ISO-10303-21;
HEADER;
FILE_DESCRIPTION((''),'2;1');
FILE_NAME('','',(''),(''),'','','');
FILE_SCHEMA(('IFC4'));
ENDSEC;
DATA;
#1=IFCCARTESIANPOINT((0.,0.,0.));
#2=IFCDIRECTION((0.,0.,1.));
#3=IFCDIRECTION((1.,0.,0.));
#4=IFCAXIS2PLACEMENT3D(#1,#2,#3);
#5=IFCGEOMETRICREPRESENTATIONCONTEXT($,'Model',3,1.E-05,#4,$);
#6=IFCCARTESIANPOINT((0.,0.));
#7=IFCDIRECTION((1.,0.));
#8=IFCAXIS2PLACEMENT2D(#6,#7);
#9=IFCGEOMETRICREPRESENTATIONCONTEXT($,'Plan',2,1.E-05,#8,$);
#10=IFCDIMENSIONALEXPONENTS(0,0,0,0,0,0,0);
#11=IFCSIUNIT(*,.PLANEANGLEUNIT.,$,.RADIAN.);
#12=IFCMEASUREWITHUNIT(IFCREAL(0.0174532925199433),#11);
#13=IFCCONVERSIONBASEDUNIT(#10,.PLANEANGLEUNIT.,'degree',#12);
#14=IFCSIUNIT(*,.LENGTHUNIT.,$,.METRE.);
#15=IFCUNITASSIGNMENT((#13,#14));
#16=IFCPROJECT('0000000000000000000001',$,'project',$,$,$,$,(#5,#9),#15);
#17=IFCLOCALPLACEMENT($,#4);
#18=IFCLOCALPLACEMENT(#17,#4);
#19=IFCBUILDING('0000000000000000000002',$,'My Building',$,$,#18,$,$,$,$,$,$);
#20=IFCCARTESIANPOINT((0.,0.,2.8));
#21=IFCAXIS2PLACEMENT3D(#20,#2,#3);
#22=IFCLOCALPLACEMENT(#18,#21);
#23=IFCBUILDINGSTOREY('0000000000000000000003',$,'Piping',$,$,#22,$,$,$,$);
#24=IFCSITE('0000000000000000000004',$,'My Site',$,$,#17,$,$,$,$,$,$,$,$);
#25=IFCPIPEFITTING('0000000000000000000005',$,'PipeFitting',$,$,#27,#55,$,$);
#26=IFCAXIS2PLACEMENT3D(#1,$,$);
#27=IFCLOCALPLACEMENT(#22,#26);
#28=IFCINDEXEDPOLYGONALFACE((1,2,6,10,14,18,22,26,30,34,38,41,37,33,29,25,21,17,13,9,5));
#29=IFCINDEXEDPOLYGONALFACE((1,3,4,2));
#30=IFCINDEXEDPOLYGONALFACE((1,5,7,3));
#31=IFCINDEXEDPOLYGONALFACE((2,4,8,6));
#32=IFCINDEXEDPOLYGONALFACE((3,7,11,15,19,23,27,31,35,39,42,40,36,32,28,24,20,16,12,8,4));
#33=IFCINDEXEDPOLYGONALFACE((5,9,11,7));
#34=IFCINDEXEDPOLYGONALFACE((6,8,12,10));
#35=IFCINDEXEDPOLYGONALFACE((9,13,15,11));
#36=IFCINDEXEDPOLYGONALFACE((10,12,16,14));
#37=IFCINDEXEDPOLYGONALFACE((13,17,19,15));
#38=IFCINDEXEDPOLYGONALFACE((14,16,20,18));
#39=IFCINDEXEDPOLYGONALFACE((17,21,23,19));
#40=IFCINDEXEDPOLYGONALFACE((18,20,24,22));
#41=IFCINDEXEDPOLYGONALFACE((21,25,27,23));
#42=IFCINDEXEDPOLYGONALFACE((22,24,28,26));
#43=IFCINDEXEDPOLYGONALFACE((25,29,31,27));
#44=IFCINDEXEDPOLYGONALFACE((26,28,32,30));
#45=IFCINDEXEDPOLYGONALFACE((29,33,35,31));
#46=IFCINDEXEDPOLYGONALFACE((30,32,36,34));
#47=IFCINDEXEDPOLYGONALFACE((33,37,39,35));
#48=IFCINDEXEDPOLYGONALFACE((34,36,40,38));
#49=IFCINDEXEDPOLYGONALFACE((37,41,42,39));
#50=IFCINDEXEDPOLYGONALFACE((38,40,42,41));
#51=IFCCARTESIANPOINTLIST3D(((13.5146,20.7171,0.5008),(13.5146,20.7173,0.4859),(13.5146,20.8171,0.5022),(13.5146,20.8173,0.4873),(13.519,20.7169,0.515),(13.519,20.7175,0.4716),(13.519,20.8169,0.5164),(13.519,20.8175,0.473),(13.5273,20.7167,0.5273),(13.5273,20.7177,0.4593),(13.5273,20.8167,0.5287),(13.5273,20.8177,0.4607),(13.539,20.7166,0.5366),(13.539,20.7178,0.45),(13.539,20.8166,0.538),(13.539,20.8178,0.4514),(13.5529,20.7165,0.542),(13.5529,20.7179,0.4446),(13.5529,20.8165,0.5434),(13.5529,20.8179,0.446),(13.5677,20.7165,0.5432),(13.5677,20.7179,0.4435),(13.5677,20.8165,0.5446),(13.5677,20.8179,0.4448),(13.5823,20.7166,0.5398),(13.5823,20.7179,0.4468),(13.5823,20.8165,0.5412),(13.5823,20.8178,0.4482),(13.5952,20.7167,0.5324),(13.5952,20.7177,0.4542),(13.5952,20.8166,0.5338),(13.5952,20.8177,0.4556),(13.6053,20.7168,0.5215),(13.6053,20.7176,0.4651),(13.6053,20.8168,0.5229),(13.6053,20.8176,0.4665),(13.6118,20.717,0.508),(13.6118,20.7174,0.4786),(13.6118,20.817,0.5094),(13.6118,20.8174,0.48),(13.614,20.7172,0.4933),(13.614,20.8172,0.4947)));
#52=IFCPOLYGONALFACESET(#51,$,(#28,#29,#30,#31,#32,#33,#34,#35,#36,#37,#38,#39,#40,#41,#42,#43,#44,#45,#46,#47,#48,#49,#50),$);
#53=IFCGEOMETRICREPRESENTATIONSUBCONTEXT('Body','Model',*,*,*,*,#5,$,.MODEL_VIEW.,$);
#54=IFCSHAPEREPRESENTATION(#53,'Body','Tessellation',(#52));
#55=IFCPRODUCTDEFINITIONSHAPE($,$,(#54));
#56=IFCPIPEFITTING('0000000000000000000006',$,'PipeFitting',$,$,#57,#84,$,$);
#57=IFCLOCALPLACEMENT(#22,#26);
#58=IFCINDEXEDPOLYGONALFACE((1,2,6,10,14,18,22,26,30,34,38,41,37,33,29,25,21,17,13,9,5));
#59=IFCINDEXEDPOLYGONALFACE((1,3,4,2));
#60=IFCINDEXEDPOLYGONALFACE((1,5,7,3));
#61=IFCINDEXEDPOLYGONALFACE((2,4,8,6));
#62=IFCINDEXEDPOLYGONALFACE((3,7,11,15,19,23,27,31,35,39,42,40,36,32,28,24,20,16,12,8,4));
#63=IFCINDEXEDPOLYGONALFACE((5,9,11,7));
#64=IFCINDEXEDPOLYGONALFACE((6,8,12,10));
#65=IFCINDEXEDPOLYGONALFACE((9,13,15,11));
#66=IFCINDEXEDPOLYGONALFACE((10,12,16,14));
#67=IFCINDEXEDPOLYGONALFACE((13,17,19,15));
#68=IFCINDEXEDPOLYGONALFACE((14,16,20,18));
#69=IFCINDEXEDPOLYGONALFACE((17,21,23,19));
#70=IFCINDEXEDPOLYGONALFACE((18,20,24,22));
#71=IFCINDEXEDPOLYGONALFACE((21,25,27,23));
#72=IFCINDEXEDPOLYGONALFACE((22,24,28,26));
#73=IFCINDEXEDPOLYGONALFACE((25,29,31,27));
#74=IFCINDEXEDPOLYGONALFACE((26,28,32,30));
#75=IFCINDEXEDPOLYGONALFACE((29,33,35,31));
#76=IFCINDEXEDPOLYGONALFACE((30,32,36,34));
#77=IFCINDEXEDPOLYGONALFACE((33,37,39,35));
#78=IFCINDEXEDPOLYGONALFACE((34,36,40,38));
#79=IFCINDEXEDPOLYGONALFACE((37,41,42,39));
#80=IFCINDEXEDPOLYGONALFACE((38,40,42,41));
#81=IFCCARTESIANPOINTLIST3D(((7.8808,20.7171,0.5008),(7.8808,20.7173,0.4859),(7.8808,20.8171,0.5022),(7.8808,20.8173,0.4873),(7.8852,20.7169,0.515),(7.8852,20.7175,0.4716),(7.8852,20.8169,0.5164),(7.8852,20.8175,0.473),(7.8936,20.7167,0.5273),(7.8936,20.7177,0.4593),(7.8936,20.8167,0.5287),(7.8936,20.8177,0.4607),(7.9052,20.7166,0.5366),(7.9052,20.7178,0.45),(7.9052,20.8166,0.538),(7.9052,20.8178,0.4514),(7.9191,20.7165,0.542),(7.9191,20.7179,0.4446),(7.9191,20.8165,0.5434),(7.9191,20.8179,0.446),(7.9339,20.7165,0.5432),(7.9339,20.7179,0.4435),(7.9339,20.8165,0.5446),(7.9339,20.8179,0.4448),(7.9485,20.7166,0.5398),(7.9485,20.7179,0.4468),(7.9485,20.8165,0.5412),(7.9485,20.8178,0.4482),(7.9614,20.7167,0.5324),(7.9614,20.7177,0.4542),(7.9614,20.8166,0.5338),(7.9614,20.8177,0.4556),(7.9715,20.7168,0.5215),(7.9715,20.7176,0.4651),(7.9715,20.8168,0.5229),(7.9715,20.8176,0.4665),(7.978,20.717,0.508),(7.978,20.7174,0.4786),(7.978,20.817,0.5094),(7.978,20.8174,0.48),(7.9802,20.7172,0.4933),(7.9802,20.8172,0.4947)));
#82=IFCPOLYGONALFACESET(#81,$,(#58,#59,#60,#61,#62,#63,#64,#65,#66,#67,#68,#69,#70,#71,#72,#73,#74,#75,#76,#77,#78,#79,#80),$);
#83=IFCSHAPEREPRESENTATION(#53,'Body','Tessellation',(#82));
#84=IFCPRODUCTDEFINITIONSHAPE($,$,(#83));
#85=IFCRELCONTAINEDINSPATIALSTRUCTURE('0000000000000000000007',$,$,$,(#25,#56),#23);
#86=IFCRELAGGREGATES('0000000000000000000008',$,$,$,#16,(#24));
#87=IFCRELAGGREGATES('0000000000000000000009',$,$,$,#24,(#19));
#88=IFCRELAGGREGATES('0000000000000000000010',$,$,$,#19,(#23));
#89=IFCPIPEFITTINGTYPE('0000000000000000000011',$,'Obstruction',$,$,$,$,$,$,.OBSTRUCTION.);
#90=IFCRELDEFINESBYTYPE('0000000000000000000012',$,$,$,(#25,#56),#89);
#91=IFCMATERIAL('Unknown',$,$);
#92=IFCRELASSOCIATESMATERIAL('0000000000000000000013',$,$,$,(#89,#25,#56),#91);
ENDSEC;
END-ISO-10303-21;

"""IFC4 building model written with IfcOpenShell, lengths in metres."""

from ifc_helpers import new_model, entity, si_unit, converted_unit, frame, origin_with_axes, origin_2d_with_axis, place, context, subcontext, project, spatial, circle, extrude, material, material_profile, profile_set, profile_usage, type_object, element, save


model = new_model("IFC4")

# Units and contexts
model_context = context("Model", 3, precision=1e-05, world=origin_with_axes())
plan_context = context("Plan", 2, precision=1e-05, world=origin_2d_with_axis())
body_context = subcontext(model_context, "Body", "Model", "MODEL_VIEW")
ifc_project = project(units=[converted_unit("PLANEANGLEUNIT", "degree", entity("IfcReal", 0.0174532925199433), si_unit("PLANEANGLEUNIT", "RADIAN"), dimensions=[0, 0, 0, 0, 0, 0, 0]), si_unit("LENGTHUNIT", "METRE")], contexts=[model_context, plan_context])

# Site, building, storey
site_placement = place(None, origin_with_axes())
site = spatial("IfcSite", under=ifc_project, at=site_placement, Name="My Site")
building_placement = place(site_placement, origin_with_axes())
building = spatial("IfcBuilding", under=site, at=building_placement, Name="My Building")
storey_placement = place(building_placement, frame((0.0, 0.0, 2.8), z_axis=(0.0, 0.0, 1.0), x_axis=(1.0, 0.0, 0.0)))
storey = spatial("IfcBuildingStorey", under=building, at=storey_placement, Name="Piping")

# Shared definitions
ifc_material = material(Name="Unknown")

# Pipe fittings
ifc_material_profile_1 = material_profile(ifc_material, circle(Radius=0.05))
ifc_profile_set_1 = profile_set([ifc_material_profile_1])
pipe_fitting_type_1 = type_object("IfcPipeFittingType", Name="Obstruction", PredefinedType="OBSTRUCTION", material=ifc_profile_set_1)
ifc_profile_usage_1 = profile_usage(ifc_profile_set_1, cardinal=5)
pipe_fitting_1_placement = place(storey_placement, frame((13.564, 20.8172, 0.4947), z_axis=(0.0, -0.999903, -0.013947), x_axis=(1.0, 0.0, 0.0)))
element("IfcPipeFitting", 1, at=pipe_fitting_1_placement, inside=storey, type_object=pipe_fitting_type_1, material=ifc_profile_usage_1, Name="PipeFitting", context=body_context, shape_type="SweptSolid", body=[
    extrude(circle(Radius=0.05), origin_with_axes(), (0.0, 0.0, 1.0), 0.1),
])
ifc_profile_usage_2 = profile_usage(ifc_profile_set_1, cardinal=5)
pipe_fitting_2_placement = place(storey_placement, frame((7.9302, 20.8172, 0.4947), z_axis=(0.0, -0.999903, -0.013947), x_axis=(1.0, 0.0, 0.0)))
element("IfcPipeFitting", 2, at=pipe_fitting_2_placement, inside=storey, type_object=pipe_fitting_type_1, material=ifc_profile_usage_2, Name="PipeFitting", context=body_context, shape_type="SweptSolid", body=[
    extrude(circle(Radius=0.05), origin_with_axes(), (0.0, 0.0, 1.0), 0.1),
])

save(model, "model.ifc")
